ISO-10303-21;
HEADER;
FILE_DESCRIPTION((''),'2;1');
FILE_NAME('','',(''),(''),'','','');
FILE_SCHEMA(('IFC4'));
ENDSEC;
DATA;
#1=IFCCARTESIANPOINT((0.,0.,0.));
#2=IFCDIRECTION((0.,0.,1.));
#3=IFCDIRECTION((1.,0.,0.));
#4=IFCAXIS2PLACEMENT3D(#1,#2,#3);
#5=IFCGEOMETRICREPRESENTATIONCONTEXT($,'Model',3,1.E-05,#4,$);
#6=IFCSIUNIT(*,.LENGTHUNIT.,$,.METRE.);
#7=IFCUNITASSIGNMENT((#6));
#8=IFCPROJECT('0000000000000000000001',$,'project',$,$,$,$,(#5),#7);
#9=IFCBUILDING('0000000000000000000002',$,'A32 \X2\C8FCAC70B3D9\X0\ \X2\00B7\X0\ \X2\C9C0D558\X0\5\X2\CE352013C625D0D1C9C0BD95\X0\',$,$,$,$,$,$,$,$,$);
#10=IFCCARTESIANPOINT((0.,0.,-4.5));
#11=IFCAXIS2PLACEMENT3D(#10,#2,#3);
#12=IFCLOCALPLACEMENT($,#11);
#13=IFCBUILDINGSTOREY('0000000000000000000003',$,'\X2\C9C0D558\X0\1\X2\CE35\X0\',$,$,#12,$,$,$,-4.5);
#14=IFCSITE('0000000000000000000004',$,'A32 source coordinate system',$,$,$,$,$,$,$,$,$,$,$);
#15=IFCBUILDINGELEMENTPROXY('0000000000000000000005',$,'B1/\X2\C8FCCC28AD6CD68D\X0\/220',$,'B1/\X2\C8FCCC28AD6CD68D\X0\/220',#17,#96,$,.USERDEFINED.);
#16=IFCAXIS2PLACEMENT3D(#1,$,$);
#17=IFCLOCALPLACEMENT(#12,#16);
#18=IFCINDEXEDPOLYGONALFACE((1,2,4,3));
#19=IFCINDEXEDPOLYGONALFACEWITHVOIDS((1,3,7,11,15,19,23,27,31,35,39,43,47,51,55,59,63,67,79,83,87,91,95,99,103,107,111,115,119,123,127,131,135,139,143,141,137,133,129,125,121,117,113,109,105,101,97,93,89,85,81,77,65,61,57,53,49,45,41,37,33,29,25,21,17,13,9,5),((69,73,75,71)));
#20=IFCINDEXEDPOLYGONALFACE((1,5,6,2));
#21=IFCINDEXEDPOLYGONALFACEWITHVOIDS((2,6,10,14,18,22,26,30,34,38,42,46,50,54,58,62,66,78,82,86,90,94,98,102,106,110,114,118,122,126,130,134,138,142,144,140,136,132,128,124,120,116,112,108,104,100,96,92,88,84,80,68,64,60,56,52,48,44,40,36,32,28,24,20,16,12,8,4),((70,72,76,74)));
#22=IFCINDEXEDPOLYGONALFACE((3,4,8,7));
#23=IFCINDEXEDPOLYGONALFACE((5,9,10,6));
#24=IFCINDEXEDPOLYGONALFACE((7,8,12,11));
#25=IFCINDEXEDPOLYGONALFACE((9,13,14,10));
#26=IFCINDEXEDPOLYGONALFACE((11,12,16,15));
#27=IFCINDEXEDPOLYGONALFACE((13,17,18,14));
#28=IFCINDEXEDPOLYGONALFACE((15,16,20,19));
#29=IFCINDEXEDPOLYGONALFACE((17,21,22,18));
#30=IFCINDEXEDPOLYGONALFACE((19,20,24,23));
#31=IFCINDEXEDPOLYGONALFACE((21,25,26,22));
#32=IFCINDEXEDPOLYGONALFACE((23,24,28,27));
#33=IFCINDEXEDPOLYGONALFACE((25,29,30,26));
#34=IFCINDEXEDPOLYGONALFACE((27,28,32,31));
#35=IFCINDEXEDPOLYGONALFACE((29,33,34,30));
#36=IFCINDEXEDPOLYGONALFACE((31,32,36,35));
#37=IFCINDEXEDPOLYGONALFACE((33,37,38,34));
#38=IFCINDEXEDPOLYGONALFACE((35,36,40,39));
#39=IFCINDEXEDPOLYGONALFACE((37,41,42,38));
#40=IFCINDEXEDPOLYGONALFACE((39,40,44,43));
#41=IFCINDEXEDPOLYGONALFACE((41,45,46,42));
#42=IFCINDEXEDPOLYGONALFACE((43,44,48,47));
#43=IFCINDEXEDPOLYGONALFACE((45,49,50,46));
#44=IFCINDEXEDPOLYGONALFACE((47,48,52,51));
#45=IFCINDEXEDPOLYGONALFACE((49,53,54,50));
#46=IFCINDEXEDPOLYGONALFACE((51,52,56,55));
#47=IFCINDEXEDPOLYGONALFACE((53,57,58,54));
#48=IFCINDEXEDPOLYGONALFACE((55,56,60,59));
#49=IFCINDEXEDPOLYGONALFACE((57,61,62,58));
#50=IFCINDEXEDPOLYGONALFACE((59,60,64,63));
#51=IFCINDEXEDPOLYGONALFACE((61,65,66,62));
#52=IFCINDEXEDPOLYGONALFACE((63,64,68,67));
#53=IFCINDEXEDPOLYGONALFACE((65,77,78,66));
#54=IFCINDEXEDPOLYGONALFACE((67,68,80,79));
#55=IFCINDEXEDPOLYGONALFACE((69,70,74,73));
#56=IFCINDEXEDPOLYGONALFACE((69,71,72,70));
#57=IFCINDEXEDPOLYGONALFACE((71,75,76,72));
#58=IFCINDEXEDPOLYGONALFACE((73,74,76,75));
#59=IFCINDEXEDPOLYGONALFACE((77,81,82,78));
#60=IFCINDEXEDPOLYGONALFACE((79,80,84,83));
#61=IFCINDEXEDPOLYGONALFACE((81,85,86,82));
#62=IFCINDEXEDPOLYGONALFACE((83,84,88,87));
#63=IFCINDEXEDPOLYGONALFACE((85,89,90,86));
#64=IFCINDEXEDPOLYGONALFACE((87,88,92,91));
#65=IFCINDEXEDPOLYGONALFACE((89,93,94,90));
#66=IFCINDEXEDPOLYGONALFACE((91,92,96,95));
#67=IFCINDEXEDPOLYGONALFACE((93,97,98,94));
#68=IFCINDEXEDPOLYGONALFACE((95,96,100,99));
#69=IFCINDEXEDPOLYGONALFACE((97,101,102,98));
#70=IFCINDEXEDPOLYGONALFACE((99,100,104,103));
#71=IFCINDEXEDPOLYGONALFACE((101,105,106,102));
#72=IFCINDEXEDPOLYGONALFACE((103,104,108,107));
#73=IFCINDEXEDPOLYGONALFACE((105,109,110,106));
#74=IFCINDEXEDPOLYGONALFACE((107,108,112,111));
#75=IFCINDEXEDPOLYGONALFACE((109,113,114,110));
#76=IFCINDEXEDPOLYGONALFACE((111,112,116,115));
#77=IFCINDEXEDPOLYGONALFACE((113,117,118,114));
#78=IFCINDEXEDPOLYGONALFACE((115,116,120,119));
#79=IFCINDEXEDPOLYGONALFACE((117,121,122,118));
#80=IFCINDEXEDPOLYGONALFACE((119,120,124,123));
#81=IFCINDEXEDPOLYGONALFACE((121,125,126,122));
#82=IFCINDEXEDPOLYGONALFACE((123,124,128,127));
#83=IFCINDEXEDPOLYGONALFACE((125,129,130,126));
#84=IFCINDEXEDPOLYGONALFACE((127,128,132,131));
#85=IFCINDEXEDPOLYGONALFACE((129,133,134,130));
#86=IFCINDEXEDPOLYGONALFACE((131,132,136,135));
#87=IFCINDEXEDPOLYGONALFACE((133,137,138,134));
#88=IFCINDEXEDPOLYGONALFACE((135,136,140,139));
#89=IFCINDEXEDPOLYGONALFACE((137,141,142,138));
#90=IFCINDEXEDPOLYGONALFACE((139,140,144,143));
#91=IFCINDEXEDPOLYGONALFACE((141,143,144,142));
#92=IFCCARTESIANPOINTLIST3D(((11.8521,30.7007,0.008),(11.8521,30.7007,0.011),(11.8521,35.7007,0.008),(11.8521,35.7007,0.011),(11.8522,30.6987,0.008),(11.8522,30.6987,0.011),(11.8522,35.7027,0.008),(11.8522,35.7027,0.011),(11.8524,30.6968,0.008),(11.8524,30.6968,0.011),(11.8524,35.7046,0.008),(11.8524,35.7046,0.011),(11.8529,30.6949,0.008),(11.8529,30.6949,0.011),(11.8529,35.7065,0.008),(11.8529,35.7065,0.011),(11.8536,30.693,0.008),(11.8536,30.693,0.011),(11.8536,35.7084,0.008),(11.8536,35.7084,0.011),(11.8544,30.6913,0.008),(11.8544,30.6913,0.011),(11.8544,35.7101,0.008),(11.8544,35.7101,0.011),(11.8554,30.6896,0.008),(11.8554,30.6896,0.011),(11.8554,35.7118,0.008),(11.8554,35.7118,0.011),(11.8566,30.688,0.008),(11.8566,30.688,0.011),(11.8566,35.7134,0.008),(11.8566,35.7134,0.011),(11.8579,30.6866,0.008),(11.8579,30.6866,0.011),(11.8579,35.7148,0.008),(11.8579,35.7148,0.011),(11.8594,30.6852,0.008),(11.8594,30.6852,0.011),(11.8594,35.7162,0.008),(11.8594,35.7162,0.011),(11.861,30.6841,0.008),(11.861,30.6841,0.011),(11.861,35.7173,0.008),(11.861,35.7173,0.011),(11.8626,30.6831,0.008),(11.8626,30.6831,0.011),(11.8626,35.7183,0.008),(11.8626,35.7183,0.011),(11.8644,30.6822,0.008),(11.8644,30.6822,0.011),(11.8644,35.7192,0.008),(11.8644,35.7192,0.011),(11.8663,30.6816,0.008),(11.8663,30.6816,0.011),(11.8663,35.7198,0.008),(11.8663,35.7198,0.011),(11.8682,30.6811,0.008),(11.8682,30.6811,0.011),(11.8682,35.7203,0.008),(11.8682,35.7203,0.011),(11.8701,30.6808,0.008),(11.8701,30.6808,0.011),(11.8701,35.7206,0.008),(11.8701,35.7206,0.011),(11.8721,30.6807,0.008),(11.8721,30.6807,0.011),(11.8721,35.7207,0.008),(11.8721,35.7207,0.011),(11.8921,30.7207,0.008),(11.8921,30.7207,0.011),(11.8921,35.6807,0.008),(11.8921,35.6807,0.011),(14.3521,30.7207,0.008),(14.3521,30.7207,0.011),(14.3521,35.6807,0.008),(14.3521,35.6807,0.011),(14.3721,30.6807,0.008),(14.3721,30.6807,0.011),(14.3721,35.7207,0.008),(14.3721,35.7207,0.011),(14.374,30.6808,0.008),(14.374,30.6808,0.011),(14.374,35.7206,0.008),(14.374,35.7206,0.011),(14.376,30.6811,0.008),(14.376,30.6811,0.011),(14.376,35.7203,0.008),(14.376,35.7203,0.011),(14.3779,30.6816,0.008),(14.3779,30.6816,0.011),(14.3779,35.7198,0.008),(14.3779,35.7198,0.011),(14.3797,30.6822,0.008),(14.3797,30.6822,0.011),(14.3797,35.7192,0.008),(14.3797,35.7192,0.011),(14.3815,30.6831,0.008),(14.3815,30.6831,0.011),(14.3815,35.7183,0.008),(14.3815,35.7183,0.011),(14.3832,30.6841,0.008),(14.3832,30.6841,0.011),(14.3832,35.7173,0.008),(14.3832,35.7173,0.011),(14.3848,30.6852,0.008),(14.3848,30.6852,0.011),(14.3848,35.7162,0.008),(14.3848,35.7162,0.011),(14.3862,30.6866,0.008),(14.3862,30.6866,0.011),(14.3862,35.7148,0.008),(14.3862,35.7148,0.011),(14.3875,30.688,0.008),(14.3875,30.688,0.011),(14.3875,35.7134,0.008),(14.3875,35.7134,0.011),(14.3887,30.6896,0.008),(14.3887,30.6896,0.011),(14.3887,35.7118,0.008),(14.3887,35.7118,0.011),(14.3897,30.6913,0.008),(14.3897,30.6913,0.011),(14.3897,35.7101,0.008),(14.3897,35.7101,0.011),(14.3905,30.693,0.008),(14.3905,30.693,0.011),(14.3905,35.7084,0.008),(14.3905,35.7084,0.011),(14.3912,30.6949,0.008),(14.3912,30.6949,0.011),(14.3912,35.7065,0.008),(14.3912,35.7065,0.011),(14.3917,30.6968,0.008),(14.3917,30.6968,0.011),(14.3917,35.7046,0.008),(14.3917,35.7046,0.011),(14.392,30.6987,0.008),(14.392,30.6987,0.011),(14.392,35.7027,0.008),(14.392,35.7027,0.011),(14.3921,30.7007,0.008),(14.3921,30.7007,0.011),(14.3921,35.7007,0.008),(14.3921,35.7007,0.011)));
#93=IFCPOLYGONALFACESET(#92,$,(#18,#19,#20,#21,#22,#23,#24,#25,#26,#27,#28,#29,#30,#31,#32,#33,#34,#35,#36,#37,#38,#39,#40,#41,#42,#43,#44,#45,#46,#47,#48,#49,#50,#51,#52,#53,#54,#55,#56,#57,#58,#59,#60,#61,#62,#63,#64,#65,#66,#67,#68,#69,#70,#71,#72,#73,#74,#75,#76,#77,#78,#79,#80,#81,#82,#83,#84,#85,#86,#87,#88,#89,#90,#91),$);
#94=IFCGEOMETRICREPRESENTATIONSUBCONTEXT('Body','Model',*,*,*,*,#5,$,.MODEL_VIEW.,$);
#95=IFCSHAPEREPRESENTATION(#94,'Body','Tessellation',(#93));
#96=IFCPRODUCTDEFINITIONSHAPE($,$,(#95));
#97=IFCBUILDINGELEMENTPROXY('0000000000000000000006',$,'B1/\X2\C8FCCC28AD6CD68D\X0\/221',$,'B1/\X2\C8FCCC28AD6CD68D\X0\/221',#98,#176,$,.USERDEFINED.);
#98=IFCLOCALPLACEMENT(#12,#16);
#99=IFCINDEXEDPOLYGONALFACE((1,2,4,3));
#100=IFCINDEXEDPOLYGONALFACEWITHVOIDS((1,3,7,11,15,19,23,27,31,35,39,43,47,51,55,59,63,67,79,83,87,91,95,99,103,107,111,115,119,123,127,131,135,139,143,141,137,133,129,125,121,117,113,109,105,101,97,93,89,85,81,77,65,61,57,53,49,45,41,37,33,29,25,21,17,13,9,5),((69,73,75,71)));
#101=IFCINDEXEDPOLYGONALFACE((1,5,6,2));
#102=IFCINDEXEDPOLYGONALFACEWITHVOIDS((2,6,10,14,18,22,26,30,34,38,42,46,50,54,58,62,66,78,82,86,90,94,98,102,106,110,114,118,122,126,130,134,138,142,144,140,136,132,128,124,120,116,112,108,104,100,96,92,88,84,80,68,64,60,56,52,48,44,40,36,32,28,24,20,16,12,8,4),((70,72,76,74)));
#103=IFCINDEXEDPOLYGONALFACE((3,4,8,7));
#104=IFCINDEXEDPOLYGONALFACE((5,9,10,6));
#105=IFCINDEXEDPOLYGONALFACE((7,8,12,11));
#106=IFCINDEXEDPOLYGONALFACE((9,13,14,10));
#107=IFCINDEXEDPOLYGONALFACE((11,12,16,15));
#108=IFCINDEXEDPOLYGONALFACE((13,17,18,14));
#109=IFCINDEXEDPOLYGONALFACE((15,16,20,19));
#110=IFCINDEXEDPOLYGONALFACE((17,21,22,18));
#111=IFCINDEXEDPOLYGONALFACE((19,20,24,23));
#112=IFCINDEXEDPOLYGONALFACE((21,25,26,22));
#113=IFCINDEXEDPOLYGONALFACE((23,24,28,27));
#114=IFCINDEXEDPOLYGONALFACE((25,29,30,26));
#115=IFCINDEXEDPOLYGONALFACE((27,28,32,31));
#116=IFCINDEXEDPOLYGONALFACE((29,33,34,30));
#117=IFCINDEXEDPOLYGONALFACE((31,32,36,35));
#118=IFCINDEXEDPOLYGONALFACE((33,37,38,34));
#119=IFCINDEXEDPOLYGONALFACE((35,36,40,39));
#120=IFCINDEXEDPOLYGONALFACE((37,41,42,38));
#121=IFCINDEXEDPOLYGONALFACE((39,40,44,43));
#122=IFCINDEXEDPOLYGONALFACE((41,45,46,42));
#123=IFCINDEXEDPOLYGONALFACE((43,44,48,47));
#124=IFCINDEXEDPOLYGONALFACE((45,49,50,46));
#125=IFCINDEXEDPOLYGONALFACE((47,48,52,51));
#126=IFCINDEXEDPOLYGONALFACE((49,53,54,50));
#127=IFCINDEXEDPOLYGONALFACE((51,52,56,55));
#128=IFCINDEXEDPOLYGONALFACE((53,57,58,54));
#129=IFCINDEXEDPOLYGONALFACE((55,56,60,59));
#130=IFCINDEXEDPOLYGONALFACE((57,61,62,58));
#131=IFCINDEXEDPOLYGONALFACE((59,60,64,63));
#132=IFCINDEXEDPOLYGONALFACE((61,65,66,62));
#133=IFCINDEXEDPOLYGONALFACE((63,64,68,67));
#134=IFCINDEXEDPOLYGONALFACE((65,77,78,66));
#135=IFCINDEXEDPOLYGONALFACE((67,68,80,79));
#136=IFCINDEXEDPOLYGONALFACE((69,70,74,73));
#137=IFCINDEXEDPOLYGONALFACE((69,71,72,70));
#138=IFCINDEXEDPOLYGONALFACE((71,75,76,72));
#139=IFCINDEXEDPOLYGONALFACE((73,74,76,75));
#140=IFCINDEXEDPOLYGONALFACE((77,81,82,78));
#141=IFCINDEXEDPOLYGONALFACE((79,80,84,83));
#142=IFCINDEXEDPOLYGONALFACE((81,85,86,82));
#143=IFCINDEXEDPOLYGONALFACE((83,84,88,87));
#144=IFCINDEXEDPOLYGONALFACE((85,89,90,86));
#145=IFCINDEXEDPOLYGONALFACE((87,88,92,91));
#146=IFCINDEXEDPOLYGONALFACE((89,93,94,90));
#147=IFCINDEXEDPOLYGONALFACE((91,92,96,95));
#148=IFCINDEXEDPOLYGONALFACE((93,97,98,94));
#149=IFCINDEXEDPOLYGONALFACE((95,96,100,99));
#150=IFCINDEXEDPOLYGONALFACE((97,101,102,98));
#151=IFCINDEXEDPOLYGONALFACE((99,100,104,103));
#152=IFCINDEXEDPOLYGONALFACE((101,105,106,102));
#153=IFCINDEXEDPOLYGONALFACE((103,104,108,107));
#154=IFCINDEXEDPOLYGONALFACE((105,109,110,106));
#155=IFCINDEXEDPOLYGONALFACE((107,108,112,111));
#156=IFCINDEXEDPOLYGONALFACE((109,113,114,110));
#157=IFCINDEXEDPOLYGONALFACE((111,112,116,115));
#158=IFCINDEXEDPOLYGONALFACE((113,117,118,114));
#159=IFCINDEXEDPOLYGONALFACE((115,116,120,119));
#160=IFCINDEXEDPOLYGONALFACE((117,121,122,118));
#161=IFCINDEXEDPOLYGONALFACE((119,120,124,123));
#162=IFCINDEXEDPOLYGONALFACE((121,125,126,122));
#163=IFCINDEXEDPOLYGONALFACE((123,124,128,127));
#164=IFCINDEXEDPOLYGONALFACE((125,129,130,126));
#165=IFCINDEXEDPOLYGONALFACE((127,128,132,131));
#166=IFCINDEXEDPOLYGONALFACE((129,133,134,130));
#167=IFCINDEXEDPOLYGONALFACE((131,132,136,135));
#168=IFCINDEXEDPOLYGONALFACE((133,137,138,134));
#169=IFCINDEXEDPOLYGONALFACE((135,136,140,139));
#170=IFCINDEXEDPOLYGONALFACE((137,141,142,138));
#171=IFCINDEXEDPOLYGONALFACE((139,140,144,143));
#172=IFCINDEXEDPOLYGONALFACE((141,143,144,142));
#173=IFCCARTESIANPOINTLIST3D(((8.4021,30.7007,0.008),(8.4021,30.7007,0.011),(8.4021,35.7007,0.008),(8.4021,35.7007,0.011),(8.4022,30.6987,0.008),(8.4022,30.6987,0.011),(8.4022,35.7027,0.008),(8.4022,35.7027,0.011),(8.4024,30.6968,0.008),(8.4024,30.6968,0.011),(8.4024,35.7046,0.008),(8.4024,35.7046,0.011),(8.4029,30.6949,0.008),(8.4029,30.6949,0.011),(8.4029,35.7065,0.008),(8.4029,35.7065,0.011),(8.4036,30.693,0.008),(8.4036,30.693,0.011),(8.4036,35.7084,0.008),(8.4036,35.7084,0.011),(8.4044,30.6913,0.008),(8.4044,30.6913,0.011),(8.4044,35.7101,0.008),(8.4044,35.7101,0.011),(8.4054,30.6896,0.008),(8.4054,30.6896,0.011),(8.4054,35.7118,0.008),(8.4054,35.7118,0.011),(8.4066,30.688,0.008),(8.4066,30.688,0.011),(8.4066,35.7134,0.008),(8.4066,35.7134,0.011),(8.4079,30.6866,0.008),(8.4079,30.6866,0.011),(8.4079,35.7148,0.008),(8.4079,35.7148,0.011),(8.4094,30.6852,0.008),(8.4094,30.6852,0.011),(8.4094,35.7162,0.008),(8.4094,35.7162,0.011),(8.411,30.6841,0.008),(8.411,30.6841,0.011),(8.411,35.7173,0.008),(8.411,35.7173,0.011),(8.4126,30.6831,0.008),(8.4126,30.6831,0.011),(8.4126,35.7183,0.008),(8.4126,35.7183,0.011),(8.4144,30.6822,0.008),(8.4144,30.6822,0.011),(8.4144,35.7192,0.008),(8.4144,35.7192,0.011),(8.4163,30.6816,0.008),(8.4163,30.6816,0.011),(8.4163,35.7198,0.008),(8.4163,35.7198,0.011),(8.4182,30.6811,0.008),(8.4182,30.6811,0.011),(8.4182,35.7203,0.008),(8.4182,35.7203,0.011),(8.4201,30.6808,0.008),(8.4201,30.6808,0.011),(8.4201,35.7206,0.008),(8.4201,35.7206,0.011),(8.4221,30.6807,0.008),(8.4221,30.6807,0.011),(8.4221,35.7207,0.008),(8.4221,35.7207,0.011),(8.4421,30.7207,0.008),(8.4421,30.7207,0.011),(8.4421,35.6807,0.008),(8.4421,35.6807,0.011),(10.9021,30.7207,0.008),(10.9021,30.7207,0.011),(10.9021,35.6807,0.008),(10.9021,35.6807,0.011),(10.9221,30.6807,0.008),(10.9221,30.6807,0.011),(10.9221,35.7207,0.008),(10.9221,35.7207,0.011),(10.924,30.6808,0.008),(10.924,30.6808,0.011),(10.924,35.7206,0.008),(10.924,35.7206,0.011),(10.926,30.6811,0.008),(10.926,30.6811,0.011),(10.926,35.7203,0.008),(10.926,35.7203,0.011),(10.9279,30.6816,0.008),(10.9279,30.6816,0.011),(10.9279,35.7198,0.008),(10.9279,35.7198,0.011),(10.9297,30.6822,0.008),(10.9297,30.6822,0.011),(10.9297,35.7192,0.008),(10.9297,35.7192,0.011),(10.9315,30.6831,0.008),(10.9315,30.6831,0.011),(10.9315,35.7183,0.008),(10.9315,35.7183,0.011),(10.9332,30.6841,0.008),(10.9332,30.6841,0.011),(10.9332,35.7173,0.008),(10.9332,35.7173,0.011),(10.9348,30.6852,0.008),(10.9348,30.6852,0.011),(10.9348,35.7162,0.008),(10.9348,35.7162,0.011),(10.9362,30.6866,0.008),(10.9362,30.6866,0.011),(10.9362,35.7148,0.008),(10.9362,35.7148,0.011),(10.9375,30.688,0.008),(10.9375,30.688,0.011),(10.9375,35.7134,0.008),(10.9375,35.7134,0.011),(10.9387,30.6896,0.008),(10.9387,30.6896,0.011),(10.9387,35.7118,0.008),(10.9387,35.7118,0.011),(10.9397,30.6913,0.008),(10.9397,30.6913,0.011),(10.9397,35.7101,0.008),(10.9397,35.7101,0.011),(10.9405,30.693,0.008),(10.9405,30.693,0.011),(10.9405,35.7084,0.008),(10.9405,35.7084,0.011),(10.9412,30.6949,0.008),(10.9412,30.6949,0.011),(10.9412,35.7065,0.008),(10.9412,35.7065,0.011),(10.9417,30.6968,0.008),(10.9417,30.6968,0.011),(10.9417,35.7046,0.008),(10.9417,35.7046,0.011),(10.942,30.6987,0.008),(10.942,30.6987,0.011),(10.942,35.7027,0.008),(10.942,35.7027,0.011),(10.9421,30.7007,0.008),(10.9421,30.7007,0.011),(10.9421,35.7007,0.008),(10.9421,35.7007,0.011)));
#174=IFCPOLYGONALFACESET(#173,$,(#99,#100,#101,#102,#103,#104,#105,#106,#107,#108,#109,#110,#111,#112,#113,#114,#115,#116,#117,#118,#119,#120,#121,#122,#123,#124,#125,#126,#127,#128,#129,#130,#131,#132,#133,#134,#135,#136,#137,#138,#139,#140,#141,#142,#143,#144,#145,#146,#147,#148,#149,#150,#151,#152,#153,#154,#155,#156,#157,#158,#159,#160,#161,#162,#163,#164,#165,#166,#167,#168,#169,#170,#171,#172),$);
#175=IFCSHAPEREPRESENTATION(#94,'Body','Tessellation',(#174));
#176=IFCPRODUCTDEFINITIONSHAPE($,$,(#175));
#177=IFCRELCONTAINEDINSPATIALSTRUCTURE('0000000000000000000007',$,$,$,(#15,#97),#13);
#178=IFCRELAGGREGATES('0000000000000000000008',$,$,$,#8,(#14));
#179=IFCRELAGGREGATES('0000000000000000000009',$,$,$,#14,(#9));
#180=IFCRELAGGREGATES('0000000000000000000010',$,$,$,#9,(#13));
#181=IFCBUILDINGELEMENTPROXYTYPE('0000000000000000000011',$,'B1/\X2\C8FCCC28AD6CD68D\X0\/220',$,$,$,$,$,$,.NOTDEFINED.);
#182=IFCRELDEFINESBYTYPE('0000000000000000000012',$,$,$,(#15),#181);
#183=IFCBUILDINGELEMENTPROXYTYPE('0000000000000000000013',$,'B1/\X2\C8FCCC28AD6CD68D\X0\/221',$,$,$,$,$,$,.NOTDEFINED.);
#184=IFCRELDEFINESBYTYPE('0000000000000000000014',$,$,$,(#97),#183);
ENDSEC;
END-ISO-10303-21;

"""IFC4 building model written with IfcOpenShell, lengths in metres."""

from ifc_helpers import new_model, si_unit, frame, origin, origin_with_axes, place, context, subcontext, project, spatial, polyline, outline, extrude, source, transform, mapped, type_object, type_shapes, element, save


model = new_model("IFC4")

# Units and contexts
model_context = context("Model", 3, precision=1e-05, world=origin_with_axes())
body_context = subcontext(model_context, "Body", "Model", "MODEL_VIEW")
ifc_project = project(units=[si_unit("LENGTHUNIT", "METRE")], contexts=[model_context])

# Site, building, storey
site = spatial("IfcSite", under=ifc_project, Name="A32 source coordinate system")
building = spatial("IfcBuilding", under=site, Name="A32 주거동 · 지하5층–옥탑지붕")
storey_placement = place(None, frame((0.0, 0.0, -4.5), z_axis=(0.0, 0.0, 1.0), x_axis=(1.0, 0.0, 0.0)))
storey = spatial("IfcBuildingStorey", under=building, at=storey_placement, Name="지하1층", Elevation=-4.5)

# Building element proxies
building_element_proxy_type_1 = type_object("IfcBuildingElementProxyType", Name="B1/주차구획/220", PredefinedType="NOTDEFINED")
shared_shape_1 = source(origin(), body_context, "Body", "SweptSolid", [
    extrude(outline(polyline([(11.8521, 35.7007), (11.8522, 35.7027), (11.8524, 35.7046), (11.8529, 35.7065), (11.8536, 35.7084), (11.8544, 35.7101), (11.8554, 35.7118), (11.8566, 35.7134), (11.8579, 35.7148), (11.8594, 35.7162), (11.861, 35.7173), (11.8626, 35.7183), (11.8644, 35.7192), (11.8663, 35.7198), (11.8682, 35.7203), (11.8701, 35.7206), (11.8721, 35.7207), (14.3721, 35.7207), (14.374, 35.7206), (14.376, 35.7203), (14.3779, 35.7198), (14.3797, 35.7192), (14.3815, 35.7183), (14.3832, 35.7173), (14.3848, 35.7162), (14.3862, 35.7148), (14.3875, 35.7134), (14.3887, 35.7118), (14.3897, 35.7101), (14.3905, 35.7084), (14.3912, 35.7065), (14.3917, 35.7046), (14.392, 35.7027), (14.3921, 35.7007), (14.3921, 30.7007), (14.392, 30.6987), (14.3917, 30.6968), (14.3912, 30.6949), (14.3905, 30.693), (14.3897, 30.6913), (14.3887, 30.6896), (14.3875, 30.688), (14.3862, 30.6866), (14.3848, 30.6852), (14.3832, 30.6841), (14.3815, 30.6831), (14.3797, 30.6822), (14.3779, 30.6816), (14.376, 30.6811), (14.374, 30.6808), (14.3721, 30.6807), (11.8721, 30.6807), (11.8701, 30.6808), (11.8682, 30.6811), (11.8663, 30.6816), (11.8644, 30.6822), (11.8626, 30.6831), (11.861, 30.6841), (11.8594, 30.6852), (11.8579, 30.6866), (11.8566, 30.688), (11.8554, 30.6896), (11.8544, 30.6913), (11.8536, 30.693), (11.8529, 30.6949), (11.8524, 30.6968), (11.8522, 30.6987), (11.8521, 30.7007), (11.8521, 35.7007)]), holes=[polyline([(11.8921, 35.6807), (11.8921, 30.7207), (14.3521, 30.7207), (14.3521, 35.6807), (11.8921, 35.6807)])]), frame((0.0, 0.0, 0.008)), (0.0, 0.0, 1.0), 0.003),
])
type_shapes(building_element_proxy_type_1, [shared_shape_1])
proxy_1_placement = place(storey_placement, origin_with_axes())
element("IfcBuildingElementProxy", 1, at=proxy_1_placement, inside=storey, type_object=building_element_proxy_type_1, Name="B1/주차구획/220", ObjectType="B1/주차구획/220", PredefinedType="USERDEFINED", context=body_context, shape_type="MappedRepresentation", body=[
    mapped(shared_shape_1, transform((0.0, 0.0, 0.0), scale=1.0)),
])
building_element_proxy_type_2 = type_object("IfcBuildingElementProxyType", Name="B1/주차구획/221", PredefinedType="NOTDEFINED")
shared_shape_2 = source(origin(), body_context, "Body", "SweptSolid", [
    extrude(outline(polyline([(8.4021, 35.7007), (8.4022, 35.7027), (8.4024, 35.7046), (8.4029, 35.7065), (8.4036, 35.7084), (8.4044, 35.7101), (8.4054, 35.7118), (8.4066, 35.7134), (8.4079, 35.7148), (8.4094, 35.7162), (8.411, 35.7173), (8.4126, 35.7183), (8.4144, 35.7192), (8.4163, 35.7198), (8.4182, 35.7203), (8.4201, 35.7206), (8.4221, 35.7207), (10.9221, 35.7207), (10.924, 35.7206), (10.926, 35.7203), (10.9279, 35.7198), (10.9297, 35.7192), (10.9315, 35.7183), (10.9332, 35.7173), (10.9348, 35.7162), (10.9362, 35.7148), (10.9375, 35.7134), (10.9387, 35.7118), (10.9397, 35.7101), (10.9405, 35.7084), (10.9412, 35.7065), (10.9417, 35.7046), (10.942, 35.7027), (10.9421, 35.7007), (10.9421, 30.7007), (10.942, 30.6987), (10.9417, 30.6968), (10.9412, 30.6949), (10.9405, 30.693), (10.9397, 30.6913), (10.9387, 30.6896), (10.9375, 30.688), (10.9362, 30.6866), (10.9348, 30.6852), (10.9332, 30.6841), (10.9315, 30.6831), (10.9297, 30.6822), (10.9279, 30.6816), (10.926, 30.6811), (10.924, 30.6808), (10.9221, 30.6807), (8.4221, 30.6807), (8.4201, 30.6808), (8.4182, 30.6811), (8.4163, 30.6816), (8.4144, 30.6822), (8.4126, 30.6831), (8.411, 30.6841), (8.4094, 30.6852), (8.4079, 30.6866), (8.4066, 30.688), (8.4054, 30.6896), (8.4044, 30.6913), (8.4036, 30.693), (8.4029, 30.6949), (8.4024, 30.6968), (8.4022, 30.6987), (8.4021, 30.7007), (8.4021, 35.7007)]), holes=[polyline([(8.4421, 35.6807), (8.4421, 30.7207), (10.9021, 30.7207), (10.9021, 35.6807), (8.4421, 35.6807)])]), frame((0.0, 0.0, 0.008)), (0.0, 0.0, 1.0), 0.003),
])
type_shapes(building_element_proxy_type_2, [shared_shape_2])
proxy_2_placement = place(storey_placement, origin_with_axes())
element("IfcBuildingElementProxy", 2, at=proxy_2_placement, inside=storey, type_object=building_element_proxy_type_2, Name="B1/주차구획/221", ObjectType="B1/주차구획/221", PredefinedType="USERDEFINED", context=body_context, shape_type="MappedRepresentation", body=[
    mapped(shared_shape_2, transform((0.0, 0.0, 0.0), scale=1.0)),
])

save(model, "model.ifc")
